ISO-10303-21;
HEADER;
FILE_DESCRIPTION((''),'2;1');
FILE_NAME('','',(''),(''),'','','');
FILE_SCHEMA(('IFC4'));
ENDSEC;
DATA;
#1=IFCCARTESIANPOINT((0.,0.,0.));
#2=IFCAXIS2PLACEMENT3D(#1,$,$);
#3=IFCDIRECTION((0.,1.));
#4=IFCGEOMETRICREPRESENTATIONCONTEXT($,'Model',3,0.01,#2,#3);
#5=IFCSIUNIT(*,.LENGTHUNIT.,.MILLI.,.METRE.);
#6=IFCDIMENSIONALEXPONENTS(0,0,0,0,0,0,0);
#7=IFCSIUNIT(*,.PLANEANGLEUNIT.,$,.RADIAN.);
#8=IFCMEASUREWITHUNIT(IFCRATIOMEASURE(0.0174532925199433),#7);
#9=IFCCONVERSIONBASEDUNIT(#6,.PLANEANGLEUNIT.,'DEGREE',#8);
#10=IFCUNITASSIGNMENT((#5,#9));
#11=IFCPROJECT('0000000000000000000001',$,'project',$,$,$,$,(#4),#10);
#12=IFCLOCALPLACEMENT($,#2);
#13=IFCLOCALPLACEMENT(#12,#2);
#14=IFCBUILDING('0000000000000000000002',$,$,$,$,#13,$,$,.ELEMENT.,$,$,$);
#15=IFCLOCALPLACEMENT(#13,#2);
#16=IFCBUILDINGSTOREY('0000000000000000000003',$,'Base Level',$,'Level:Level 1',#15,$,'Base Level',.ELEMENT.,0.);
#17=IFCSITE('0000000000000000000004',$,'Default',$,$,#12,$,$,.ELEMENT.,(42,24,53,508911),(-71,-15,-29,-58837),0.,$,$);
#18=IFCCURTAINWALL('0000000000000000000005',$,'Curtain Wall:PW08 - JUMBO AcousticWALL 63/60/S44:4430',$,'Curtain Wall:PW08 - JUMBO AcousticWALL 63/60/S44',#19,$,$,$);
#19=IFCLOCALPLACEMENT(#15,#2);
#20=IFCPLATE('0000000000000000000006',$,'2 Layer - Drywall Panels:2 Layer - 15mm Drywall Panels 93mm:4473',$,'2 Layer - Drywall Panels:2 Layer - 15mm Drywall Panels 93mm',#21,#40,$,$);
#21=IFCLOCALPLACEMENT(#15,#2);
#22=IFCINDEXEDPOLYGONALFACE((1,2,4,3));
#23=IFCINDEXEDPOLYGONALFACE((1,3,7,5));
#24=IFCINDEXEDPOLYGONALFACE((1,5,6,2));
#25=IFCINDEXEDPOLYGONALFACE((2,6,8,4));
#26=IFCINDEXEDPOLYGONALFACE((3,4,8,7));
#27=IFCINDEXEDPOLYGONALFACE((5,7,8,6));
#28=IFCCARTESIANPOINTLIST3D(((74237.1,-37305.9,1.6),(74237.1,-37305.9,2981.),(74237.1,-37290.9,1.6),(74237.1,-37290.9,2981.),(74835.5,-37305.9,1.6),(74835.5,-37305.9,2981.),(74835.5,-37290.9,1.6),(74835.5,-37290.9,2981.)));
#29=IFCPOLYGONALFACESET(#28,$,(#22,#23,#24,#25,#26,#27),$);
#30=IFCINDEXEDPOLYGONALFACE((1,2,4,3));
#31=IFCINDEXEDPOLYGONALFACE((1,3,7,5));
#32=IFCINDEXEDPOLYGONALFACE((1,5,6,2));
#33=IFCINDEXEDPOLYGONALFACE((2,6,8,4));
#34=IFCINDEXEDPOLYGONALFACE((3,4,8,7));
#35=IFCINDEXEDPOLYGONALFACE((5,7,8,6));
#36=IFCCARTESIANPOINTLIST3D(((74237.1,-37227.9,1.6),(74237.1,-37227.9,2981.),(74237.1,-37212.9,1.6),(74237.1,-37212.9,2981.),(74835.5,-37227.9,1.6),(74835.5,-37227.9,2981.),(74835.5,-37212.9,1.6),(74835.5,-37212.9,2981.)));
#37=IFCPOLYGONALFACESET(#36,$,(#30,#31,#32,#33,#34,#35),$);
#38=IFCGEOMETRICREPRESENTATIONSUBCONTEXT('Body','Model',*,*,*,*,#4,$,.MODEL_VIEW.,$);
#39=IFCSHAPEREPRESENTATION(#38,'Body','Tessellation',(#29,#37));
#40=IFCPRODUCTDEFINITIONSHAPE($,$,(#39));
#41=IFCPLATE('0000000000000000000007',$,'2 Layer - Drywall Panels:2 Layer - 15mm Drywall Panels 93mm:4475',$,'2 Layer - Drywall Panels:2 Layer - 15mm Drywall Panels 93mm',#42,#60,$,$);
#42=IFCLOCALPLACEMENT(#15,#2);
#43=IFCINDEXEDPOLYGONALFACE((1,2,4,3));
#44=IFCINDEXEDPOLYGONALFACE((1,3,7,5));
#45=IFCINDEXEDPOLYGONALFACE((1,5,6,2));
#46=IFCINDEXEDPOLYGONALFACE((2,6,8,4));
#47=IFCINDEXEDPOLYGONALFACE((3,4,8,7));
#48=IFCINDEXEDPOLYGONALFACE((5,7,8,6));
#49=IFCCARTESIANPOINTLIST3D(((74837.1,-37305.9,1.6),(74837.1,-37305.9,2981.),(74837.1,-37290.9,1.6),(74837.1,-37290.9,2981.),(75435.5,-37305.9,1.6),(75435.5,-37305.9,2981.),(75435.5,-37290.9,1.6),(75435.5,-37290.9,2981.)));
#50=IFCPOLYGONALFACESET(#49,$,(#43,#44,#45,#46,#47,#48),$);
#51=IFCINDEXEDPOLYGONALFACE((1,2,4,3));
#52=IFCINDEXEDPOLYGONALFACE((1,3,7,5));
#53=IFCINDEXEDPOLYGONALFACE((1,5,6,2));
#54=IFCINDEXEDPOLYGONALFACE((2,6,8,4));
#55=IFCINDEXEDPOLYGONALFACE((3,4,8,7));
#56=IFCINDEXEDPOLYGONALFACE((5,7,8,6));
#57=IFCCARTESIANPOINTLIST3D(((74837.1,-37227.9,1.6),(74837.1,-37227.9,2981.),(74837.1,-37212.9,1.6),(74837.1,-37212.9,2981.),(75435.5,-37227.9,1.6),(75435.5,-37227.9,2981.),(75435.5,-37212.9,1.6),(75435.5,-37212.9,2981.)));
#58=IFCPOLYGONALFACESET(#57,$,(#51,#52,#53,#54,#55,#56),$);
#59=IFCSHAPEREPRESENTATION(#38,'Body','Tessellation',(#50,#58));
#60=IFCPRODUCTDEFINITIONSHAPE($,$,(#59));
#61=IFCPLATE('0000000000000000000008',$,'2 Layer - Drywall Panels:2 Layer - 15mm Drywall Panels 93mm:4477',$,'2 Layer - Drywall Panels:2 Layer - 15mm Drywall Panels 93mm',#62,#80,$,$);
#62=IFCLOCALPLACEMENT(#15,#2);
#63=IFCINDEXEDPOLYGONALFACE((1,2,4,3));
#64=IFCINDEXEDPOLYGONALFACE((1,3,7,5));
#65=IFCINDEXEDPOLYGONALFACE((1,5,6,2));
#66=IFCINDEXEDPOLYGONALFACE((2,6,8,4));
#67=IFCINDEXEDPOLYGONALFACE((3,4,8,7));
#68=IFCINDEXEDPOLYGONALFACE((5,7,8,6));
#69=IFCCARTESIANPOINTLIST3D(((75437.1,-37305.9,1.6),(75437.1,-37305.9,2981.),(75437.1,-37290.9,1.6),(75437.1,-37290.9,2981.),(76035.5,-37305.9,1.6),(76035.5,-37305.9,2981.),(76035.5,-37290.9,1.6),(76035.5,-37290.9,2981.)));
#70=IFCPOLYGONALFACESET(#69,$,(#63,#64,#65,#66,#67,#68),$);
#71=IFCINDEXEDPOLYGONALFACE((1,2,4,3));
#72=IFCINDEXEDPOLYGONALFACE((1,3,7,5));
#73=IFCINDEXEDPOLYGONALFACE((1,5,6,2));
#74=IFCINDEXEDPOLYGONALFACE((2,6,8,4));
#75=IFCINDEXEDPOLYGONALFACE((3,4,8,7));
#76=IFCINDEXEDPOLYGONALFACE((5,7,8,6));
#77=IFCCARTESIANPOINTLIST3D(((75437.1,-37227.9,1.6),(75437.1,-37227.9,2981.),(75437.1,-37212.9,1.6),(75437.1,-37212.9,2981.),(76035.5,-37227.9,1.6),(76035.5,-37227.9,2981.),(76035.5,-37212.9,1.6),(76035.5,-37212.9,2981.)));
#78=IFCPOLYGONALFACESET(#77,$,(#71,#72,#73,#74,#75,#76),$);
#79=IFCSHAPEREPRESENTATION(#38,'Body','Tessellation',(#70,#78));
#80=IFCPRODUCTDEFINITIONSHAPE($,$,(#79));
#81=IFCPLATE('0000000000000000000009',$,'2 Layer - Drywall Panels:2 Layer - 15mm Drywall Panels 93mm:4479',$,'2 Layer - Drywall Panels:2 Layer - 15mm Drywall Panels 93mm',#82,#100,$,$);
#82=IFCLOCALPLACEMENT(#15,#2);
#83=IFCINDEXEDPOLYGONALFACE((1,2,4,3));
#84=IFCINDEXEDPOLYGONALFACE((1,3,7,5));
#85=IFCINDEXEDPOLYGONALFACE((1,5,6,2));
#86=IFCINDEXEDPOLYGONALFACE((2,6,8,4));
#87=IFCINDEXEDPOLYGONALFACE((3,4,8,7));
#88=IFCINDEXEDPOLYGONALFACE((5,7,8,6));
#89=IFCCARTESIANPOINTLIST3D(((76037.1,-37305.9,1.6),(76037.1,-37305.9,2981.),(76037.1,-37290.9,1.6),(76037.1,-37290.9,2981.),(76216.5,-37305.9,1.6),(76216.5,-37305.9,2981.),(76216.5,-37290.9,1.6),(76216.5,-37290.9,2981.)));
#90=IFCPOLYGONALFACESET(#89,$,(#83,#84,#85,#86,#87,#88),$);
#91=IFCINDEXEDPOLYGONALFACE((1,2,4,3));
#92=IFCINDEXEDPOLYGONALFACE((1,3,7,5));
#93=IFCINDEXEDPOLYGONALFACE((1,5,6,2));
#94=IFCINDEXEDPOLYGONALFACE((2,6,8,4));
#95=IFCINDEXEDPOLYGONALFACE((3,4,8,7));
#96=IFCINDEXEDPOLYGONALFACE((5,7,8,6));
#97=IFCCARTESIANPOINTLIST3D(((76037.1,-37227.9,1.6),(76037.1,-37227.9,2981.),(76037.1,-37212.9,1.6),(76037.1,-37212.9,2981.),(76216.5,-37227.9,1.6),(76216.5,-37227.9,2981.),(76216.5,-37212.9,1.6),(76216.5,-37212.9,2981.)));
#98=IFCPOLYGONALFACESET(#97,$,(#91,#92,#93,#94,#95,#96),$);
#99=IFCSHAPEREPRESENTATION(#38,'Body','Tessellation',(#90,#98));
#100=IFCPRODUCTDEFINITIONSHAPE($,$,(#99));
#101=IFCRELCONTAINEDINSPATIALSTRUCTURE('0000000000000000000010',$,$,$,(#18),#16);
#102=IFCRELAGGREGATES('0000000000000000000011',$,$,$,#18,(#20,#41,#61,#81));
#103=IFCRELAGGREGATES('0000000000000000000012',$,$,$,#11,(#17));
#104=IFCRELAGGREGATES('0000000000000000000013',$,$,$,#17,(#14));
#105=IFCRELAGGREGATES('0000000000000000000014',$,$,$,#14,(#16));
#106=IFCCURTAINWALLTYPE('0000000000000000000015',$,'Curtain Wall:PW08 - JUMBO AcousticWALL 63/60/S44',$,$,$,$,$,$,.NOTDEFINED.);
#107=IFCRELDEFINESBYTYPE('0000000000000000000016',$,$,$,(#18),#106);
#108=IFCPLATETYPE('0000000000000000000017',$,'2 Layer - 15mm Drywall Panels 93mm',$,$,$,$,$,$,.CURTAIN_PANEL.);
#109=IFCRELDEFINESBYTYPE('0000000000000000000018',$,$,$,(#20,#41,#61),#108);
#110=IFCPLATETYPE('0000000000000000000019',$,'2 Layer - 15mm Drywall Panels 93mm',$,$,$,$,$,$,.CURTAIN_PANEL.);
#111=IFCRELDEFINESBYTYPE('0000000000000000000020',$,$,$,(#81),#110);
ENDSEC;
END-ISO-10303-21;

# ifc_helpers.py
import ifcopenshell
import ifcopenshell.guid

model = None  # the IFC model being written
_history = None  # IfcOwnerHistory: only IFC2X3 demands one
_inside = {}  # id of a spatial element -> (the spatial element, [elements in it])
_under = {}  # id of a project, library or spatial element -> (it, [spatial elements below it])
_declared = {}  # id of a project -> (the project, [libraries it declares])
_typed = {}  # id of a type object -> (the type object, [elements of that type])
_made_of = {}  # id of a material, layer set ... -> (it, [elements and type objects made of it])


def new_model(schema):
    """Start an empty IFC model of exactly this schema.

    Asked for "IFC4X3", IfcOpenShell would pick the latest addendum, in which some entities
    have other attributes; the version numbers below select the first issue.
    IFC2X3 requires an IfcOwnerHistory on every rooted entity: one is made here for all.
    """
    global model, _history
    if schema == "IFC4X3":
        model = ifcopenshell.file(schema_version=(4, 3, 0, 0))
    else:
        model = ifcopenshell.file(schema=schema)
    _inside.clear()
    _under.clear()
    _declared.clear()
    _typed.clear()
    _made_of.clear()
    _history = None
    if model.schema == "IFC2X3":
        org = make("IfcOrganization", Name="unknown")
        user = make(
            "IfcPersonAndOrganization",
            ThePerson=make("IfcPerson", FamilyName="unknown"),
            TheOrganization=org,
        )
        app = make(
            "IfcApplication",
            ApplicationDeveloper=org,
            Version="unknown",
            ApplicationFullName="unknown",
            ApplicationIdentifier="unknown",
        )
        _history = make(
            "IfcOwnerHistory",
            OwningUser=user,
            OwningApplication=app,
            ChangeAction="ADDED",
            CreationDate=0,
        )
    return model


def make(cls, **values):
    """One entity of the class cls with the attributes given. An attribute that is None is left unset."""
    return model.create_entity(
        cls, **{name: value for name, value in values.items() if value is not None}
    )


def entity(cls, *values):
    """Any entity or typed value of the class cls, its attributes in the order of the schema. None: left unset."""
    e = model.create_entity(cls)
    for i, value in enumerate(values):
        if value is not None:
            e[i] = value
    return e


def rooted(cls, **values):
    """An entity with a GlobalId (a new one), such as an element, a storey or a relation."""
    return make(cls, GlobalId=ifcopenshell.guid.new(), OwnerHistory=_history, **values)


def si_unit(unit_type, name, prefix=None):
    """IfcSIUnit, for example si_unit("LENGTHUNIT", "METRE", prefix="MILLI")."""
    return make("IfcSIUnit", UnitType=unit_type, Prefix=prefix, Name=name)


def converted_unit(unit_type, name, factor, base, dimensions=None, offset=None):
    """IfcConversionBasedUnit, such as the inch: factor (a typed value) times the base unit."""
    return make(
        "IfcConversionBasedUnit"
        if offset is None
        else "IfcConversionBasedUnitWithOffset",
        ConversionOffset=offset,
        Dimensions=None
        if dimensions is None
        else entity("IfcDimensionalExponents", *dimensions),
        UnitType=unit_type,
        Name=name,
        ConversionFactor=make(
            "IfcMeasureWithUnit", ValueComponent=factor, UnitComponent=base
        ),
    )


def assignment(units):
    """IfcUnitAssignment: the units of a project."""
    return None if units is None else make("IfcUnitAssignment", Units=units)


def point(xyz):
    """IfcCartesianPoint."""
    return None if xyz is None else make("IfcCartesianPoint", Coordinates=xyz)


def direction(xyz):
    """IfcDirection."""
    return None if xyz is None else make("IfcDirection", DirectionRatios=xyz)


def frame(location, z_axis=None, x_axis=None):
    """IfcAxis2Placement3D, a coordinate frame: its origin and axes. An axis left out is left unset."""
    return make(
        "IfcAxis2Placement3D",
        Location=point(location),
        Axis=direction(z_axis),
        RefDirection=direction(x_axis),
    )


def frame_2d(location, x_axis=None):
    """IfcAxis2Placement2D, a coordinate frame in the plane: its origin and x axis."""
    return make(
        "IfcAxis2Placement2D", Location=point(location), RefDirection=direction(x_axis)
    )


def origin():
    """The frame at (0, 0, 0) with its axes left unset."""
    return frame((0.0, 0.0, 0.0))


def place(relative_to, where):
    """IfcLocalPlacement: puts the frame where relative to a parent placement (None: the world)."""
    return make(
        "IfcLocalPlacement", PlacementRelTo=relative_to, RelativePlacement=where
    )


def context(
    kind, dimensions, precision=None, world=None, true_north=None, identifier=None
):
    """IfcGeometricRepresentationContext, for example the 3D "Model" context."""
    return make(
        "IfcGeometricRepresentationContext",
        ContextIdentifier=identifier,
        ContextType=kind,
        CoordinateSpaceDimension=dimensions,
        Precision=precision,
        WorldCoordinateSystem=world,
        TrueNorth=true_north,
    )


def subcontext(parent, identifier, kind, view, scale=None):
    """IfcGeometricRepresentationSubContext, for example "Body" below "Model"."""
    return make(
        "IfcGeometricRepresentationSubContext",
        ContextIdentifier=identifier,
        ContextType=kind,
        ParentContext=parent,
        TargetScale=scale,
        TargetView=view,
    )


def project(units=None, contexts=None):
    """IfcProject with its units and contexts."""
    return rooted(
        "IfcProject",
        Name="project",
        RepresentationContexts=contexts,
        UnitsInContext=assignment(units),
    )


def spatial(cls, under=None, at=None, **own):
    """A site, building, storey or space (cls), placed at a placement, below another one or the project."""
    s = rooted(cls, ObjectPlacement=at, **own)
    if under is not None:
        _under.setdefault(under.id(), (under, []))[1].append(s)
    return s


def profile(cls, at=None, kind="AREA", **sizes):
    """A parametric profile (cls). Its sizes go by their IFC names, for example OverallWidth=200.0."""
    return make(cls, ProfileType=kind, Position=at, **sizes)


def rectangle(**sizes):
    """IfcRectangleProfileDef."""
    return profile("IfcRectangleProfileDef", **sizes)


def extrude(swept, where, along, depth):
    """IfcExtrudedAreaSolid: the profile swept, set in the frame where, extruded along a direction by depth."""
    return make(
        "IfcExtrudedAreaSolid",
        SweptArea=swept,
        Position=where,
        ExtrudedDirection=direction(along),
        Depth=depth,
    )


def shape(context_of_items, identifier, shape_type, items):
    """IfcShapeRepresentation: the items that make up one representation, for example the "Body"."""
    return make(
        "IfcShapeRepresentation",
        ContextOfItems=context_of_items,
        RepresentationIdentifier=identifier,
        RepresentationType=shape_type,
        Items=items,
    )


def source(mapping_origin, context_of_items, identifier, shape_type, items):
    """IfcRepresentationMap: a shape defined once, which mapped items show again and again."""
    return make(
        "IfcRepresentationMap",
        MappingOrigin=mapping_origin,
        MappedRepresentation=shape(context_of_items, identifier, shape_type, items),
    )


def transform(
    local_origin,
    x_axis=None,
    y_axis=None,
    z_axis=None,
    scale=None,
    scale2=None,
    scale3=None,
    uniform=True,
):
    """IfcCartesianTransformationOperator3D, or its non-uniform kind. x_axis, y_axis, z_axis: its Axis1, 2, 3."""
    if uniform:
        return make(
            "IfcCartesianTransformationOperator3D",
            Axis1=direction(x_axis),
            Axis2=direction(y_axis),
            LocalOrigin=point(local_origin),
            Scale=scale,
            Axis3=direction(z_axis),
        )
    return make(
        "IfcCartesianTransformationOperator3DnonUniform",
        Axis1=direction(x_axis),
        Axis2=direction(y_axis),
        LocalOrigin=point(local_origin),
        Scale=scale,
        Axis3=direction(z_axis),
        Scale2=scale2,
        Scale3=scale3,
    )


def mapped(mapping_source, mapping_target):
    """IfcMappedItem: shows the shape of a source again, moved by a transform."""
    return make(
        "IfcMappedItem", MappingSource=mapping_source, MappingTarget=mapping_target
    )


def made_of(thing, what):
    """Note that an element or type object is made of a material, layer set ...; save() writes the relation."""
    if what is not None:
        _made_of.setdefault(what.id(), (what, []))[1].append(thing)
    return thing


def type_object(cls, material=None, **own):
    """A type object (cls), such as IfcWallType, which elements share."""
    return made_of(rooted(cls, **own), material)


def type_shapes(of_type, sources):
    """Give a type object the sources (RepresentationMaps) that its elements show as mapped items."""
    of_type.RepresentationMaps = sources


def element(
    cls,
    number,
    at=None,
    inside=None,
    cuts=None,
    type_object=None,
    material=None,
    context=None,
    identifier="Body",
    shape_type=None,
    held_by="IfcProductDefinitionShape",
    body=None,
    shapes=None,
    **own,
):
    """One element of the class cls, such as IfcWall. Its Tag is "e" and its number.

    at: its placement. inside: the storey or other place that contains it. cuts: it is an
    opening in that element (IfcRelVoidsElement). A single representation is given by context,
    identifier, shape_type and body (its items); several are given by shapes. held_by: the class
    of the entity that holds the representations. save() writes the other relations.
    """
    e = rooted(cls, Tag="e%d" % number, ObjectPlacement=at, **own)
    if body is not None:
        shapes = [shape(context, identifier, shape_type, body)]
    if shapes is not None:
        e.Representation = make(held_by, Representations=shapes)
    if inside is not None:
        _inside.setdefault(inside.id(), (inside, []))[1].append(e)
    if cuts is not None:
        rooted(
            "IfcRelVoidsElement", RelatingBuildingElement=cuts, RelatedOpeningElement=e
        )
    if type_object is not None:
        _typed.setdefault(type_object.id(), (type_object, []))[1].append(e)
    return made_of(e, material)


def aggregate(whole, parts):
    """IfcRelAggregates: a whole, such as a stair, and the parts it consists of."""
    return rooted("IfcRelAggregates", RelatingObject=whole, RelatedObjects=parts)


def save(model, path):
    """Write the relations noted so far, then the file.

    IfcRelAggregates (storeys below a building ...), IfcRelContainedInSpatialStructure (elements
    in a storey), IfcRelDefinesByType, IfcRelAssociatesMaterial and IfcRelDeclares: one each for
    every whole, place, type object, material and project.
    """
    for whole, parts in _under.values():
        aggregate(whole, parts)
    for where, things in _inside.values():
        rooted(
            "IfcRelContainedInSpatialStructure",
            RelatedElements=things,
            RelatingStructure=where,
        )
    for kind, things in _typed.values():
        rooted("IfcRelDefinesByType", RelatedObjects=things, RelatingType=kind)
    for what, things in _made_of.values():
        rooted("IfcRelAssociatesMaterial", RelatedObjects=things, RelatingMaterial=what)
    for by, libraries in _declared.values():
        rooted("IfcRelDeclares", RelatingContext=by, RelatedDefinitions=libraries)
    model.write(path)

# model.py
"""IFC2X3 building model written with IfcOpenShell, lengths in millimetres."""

from ifc_helpers import new_model, entity, si_unit, converted_unit, direction, frame, frame_2d, origin, place, context, subcontext, project, spatial, rectangle, extrude, source, transform, mapped, type_object, type_shapes, element, aggregate, save


model = new_model("IFC2X3")

# Units and contexts
model_context = context("Model", 3, precision=0.01, world=origin(), true_north=direction((0.0, 1.0)))
body_context = subcontext(model_context, "Body", "Model", "MODEL_VIEW")
ifc_project = project(units=[si_unit("LENGTHUNIT", "METRE", prefix="MILLI"), converted_unit("PLANEANGLEUNIT", "DEGREE", entity("IfcRatioMeasure", 0.0174532925199433), si_unit("PLANEANGLEUNIT", "RADIAN"), dimensions=[0, 0, 0, 0, 0, 0, 0])], contexts=[model_context])

# Site, building, storey
site_placement = place(None, origin())
site = spatial("IfcSite", under=ifc_project, at=site_placement, Name="Default", CompositionType="ELEMENT", RefLatitude=(42, 24, 53, 508911), RefLongitude=(-71, -15, -29, -58837), RefElevation=0.0)
building_placement = place(site_placement, origin())
building = spatial("IfcBuilding", under=site, at=building_placement, CompositionType="ELEMENT")
storey_placement = place(building_placement, origin())
storey = spatial("IfcBuildingStorey", under=building, at=storey_placement, Name="Base Level", ObjectType="Level:Level 1", LongName="Base Level", CompositionType="ELEMENT", Elevation=0.0)

# Curtain wall, plates
curtain_wall_type = type_object("IfcCurtainWallType", Name="Curtain Wall:PW08 - JUMBO AcousticWALL 63/60/S44", PredefinedType="NOTDEFINED")
curtain_wall_placement = place(building_placement, origin())
curtain_wall = element("IfcCurtainWall", 1, at=curtain_wall_placement, inside=storey, type_object=curtain_wall_type, Name="Curtain Wall:PW08 - JUMBO AcousticWALL 63/60/S44:4430", ObjectType="Curtain Wall:PW08 - JUMBO AcousticWALL 63/60/S44")
plate_type_1 = type_object("IfcPlateType", Name="2 Layer - 15mm Drywall Panels 93mm", PredefinedType="CURTAIN_PANEL")
shared_shape_1 = source(origin(), body_context, "Body", "SweptSolid", [
    extrude(rectangle(XDim=598.4, YDim=15.0, at=frame_2d((0.0, 0.0), x_axis=(1.0, 0.0))), frame((0.0, -39.0, 0.0), z_axis=(0.0, 0.0, 1.0), x_axis=(-1.0, 0.0, 0.0)), (0.0, 0.0, 1.0), 2979.4),
    extrude(rectangle(XDim=15.0, YDim=598.4, at=frame_2d((0.0, 0.0), x_axis=(1.0, 0.0))), frame((0.0, 39.0, 0.0), z_axis=(0.0, 0.0, 1.0), x_axis=(0.0, 1.0, 0.0)), (0.0, 0.0, 1.0), 2979.4),
])
type_shapes(plate_type_1, [shared_shape_1])
plate_1_placement = place(curtain_wall_placement, frame((74536.3, -37259.4, 1.6)))
plate_1 = element("IfcPlate", 2, at=plate_1_placement, type_object=plate_type_1, Name="2 Layer - Drywall Panels:2 Layer - 15mm Drywall Panels 93mm:4473", ObjectType="2 Layer - Drywall Panels:2 Layer - 15mm Drywall Panels 93mm", context=body_context, shape_type="MappedRepresentation", body=[
    mapped(shared_shape_1, transform((0.0, 0.0, 0.0), scale=1.0)),
])
plate_2_placement = place(curtain_wall_placement, frame((75136.3, -37259.4, 1.6)))
plate_2 = element("IfcPlate", 3, at=plate_2_placement, type_object=plate_type_1, Name="2 Layer - Drywall Panels:2 Layer - 15mm Drywall Panels 93mm:4475", ObjectType="2 Layer - Drywall Panels:2 Layer - 15mm Drywall Panels 93mm", context=body_context, shape_type="MappedRepresentation", body=[
    mapped(shared_shape_1, transform((0.0, 0.0, 0.0), scale=1.0)),
])
plate_3_placement = place(curtain_wall_placement, frame((75736.3, -37259.4, 1.6)))
plate_3 = element("IfcPlate", 4, at=plate_3_placement, type_object=plate_type_1, Name="2 Layer - Drywall Panels:2 Layer - 15mm Drywall Panels 93mm:4477", ObjectType="2 Layer - Drywall Panels:2 Layer - 15mm Drywall Panels 93mm", context=body_context, shape_type="MappedRepresentation", body=[
    mapped(shared_shape_1, transform((0.0, 0.0, 0.0), scale=1.0)),
])
plate_type_2 = type_object("IfcPlateType", Name="2 Layer - 15mm Drywall Panels 93mm", PredefinedType="CURTAIN_PANEL")
shared_shape_2 = source(origin(), body_context, "Body", "SweptSolid", [
    extrude(rectangle(XDim=179.4, YDim=15.0, at=frame_2d((0.0, 0.0), x_axis=(1.0, 0.0))), frame((0.0, -39.0, 0.0), z_axis=(0.0, 0.0, 1.0), x_axis=(-1.0, 0.0, 0.0)), (0.0, 0.0, 1.0), 2979.4),
    extrude(rectangle(XDim=15.0, YDim=179.4, at=frame_2d((0.0, 0.0), x_axis=(1.0, 0.0))), frame((0.0, 39.0, 0.0), z_axis=(0.0, 0.0, 1.0), x_axis=(0.0, 1.0, 0.0)), (0.0, 0.0, 1.0), 2979.4),
])
type_shapes(plate_type_2, [shared_shape_2])
plate_4_placement = place(curtain_wall_placement, frame((76126.8, -37259.4, 1.6)))
plate_4 = element("IfcPlate", 5, at=plate_4_placement, type_object=plate_type_2, Name="2 Layer - Drywall Panels:2 Layer - 15mm Drywall Panels 93mm:4479", ObjectType="2 Layer - Drywall Panels:2 Layer - 15mm Drywall Panels 93mm", context=body_context, shape_type="MappedRepresentation", body=[
    mapped(shared_shape_2, transform((0.0, 0.0, 0.0), scale=1.0)),
])
aggregate(curtain_wall, [plate_1, plate_2, plate_3, plate_4])

save(model, "model.ifc")
